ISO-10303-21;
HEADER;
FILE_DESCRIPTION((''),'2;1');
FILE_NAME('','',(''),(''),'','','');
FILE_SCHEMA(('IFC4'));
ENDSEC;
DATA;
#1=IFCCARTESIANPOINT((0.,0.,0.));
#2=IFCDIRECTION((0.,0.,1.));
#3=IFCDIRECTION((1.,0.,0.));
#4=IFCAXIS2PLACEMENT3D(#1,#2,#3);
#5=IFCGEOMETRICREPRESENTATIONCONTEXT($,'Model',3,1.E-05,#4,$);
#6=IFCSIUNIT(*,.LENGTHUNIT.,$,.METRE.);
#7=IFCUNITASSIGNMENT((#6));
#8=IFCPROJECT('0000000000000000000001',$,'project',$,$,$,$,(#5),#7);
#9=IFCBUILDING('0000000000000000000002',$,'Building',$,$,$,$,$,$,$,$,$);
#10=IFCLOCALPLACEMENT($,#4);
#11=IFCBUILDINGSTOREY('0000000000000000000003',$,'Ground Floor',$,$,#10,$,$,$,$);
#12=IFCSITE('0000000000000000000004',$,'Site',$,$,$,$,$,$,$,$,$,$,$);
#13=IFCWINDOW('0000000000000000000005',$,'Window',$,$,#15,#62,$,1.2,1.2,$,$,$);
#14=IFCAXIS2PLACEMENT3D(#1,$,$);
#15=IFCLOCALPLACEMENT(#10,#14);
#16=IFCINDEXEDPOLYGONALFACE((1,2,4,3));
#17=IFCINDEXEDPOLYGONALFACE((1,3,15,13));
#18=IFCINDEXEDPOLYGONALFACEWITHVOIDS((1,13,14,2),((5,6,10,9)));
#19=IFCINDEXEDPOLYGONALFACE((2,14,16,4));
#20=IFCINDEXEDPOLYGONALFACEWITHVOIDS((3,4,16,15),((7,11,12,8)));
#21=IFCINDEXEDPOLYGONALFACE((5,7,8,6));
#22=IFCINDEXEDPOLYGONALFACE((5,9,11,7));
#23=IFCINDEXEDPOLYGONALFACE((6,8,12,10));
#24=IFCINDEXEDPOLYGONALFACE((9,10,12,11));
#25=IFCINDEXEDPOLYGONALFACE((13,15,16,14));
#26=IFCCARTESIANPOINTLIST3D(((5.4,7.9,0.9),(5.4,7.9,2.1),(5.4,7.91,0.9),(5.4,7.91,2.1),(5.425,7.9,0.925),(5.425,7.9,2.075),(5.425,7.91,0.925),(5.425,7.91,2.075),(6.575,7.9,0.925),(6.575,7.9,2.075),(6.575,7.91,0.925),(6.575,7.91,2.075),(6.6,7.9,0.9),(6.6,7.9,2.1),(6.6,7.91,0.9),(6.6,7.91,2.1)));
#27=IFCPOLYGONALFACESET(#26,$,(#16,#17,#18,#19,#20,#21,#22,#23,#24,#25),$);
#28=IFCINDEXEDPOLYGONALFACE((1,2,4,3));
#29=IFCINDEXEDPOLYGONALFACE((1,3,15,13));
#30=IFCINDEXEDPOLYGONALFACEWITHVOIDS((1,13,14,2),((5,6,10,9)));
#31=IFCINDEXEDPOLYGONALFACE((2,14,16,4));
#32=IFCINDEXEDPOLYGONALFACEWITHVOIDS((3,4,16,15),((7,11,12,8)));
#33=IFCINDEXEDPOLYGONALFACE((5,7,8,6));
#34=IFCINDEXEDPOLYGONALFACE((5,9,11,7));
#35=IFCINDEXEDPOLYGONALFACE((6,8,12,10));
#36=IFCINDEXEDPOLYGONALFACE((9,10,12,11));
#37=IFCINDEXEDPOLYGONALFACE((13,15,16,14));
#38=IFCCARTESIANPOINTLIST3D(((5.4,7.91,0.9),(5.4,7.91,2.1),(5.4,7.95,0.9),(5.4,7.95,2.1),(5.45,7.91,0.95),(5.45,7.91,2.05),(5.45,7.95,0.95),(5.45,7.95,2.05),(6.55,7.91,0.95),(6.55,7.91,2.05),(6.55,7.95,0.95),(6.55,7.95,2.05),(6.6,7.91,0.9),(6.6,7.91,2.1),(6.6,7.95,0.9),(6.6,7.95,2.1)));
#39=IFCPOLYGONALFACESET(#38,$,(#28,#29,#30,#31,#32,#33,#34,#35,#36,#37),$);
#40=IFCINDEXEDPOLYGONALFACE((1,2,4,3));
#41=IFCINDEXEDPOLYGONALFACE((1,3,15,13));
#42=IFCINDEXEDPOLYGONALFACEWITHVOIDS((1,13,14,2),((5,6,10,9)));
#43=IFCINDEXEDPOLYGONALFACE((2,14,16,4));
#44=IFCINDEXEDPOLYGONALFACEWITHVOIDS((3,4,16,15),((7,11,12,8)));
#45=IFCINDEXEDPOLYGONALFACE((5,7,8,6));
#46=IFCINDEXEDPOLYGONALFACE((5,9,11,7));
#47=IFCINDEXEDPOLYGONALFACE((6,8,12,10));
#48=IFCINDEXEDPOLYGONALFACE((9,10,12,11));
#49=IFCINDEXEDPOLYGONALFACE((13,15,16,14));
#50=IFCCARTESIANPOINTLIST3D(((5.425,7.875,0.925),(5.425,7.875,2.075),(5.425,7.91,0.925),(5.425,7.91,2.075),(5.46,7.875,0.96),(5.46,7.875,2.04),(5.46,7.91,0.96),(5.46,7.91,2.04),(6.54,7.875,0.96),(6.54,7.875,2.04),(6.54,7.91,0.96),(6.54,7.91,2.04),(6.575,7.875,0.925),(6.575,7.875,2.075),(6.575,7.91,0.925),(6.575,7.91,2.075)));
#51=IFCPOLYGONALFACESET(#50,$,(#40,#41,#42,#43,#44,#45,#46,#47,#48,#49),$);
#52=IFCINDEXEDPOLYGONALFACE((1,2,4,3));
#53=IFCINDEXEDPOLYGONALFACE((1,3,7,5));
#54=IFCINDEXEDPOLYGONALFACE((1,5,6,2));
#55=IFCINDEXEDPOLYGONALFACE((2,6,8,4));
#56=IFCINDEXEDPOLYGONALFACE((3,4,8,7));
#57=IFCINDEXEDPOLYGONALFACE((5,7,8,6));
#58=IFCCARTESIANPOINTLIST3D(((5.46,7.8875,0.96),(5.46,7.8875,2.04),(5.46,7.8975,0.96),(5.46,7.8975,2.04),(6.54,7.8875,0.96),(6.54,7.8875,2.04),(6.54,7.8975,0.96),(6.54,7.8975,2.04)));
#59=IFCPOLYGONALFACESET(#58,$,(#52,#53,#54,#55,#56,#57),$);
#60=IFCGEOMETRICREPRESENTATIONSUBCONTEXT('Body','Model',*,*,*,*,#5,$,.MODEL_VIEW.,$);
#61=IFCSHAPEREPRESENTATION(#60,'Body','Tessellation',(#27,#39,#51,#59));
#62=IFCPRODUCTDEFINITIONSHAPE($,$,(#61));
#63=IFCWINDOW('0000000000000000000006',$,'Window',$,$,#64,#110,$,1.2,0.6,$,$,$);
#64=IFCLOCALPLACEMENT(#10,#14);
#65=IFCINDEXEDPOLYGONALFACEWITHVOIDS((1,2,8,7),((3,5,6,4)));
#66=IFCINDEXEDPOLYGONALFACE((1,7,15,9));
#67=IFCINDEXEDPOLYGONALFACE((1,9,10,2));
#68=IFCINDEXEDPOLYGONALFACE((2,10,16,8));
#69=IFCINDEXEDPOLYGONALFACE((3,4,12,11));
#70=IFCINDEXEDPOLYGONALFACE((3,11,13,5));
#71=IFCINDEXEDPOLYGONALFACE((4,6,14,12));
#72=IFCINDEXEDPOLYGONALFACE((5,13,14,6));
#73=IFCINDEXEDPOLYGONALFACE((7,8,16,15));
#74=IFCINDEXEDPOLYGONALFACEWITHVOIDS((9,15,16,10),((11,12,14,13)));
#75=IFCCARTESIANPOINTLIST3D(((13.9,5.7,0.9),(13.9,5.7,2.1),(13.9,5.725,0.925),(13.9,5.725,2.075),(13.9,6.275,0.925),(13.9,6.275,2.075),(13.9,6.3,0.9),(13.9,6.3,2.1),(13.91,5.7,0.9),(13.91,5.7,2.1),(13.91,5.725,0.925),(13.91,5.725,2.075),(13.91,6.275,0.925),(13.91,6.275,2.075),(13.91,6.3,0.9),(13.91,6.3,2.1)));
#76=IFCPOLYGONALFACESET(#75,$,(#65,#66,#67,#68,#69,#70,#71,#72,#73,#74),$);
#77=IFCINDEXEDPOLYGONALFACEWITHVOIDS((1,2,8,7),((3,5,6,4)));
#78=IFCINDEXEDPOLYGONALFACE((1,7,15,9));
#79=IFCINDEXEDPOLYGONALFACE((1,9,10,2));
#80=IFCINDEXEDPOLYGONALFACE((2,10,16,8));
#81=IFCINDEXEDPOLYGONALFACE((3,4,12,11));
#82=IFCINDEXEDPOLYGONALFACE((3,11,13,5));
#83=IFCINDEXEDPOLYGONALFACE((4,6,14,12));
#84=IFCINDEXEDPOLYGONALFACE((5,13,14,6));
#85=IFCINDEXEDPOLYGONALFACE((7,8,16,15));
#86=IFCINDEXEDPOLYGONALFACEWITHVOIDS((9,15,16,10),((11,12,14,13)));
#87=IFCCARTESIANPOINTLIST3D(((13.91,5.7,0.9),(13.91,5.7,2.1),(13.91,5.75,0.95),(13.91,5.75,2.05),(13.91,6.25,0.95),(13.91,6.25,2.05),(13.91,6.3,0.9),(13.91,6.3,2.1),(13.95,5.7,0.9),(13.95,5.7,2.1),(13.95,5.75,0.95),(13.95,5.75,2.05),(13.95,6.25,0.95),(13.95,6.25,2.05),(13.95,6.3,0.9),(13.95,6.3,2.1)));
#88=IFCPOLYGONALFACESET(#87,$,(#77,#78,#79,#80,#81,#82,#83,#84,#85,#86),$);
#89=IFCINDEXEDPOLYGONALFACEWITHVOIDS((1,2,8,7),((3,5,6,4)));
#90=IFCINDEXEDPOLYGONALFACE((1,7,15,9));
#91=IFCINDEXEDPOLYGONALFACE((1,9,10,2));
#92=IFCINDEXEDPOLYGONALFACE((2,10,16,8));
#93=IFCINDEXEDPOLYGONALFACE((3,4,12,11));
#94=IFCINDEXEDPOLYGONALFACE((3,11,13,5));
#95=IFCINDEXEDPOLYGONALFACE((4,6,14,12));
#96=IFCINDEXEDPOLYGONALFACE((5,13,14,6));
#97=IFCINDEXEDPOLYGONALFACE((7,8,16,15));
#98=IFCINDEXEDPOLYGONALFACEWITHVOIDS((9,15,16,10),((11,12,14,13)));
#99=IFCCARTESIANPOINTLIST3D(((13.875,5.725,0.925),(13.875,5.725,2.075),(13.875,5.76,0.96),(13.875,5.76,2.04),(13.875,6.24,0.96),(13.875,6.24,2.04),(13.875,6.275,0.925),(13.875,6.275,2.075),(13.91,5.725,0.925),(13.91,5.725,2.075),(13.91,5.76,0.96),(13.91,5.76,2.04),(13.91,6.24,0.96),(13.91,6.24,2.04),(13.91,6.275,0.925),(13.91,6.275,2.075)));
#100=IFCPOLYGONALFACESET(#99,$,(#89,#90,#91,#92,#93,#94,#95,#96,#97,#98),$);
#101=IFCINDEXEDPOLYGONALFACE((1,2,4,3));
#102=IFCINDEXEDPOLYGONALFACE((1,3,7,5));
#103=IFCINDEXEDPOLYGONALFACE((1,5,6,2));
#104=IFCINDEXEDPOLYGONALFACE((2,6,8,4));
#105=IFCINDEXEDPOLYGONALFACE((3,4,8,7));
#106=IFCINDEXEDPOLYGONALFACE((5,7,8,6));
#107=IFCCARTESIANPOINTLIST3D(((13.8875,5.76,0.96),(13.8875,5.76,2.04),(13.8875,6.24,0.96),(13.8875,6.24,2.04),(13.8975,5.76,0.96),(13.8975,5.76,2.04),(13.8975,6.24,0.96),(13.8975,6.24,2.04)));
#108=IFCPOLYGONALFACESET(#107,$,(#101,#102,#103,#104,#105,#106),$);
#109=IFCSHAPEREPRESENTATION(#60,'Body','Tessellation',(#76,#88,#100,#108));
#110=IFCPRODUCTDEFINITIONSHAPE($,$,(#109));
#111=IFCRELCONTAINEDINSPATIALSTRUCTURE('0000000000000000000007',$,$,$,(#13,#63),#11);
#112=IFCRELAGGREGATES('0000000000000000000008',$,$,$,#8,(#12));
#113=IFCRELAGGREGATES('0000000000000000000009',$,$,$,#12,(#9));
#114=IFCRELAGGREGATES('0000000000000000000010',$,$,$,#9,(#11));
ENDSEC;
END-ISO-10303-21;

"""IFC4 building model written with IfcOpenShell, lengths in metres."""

from ifc_helpers import new_model, si_unit, frame, origin_with_axes, place, context, subcontext, project, spatial, line, indexed_curve, outline, extrude, element, save


model = new_model("IFC4")

# Units and contexts
model_context = context("Model", 3, precision=1e-05, world=origin_with_axes())
body_context = subcontext(model_context, "Body", "Model", "MODEL_VIEW")
ifc_project = project(units=[si_unit("LENGTHUNIT", "METRE")], contexts=[model_context])

# Site, building, storey
site = spatial("IfcSite", under=ifc_project, Name="Site")
building = spatial("IfcBuilding", under=site, Name="Building")
storey_placement = place(None, origin_with_axes())
storey = spatial("IfcBuildingStorey", under=building, at=storey_placement, Name="Ground Floor")

# Windows
window_1_placement = place(storey_placement, frame((6.6, 8.0, 0.9), z_axis=(0.0, 0.0, 1.0), x_axis=(-1.0, 0.0, 0.0)))
element("IfcWindow", 1, at=window_1_placement, inside=storey, Name="Window", OverallHeight=1.2, OverallWidth=1.2, context=body_context, shape_type="SweptSolid", body=[
    extrude(outline(indexed_curve([(0.0, 0.0), (1.2, 0.0), (1.2, 1.2), (0.0, 1.2)], segments=[line(1, 2, 3, 4, 1)]), holes=[indexed_curve([(0.025, 0.025), (1.175, 0.025), (1.175, 1.175), (0.025, 1.175)], segments=[line(1, 2, 3, 4, 1)])]), frame((0.0, 0.09, 0.0), z_axis=(0.0, -1.0, 0.0), x_axis=(1.0, 0.0, 0.0)), (0.0, 0.0, -1.0), 0.01),
    extrude(outline(indexed_curve([(0.0, 0.0), (1.2, 0.0), (1.2, 1.2), (0.0, 1.2)], segments=[line(1, 2, 3, 4, 1)]), holes=[indexed_curve([(0.05, 0.05), (1.15, 0.05), (1.15, 1.15), (0.05, 1.15)], segments=[line(1, 2, 3, 4, 1)])]), frame((0.0, 0.05, 0.0), z_axis=(0.0, -1.0, 0.0), x_axis=(1.0, 0.0, 0.0)), (0.0, 0.0, -1.0), 0.04),
    extrude(outline(indexed_curve([(0.0, 0.0), (1.15, 0.0), (1.15, 1.15), (0.0, 1.15)], segments=[line(1, 2, 3, 4, 1)]), holes=[indexed_curve([(0.035, 0.035), (1.115, 0.035), (1.115, 1.115), (0.035, 1.115)], segments=[line(1, 2, 3, 4, 1)])]), frame((0.025, 0.09, 0.025), z_axis=(0.0, -1.0, 0.0), x_axis=(1.0, 0.0, 0.0)), (0.0, 0.0, -1.0), 0.035),
    extrude(outline(indexed_curve([(0.035, 0.035), (1.115, 0.035), (1.115, 1.115), (0.035, 1.115)], segments=[line(1, 2, 3, 4, 1)])), frame((0.025, 0.1025, 0.025), z_axis=(0.0, -1.0, 0.0), x_axis=(1.0, 0.0, 0.0)), (0.0, 0.0, -1.0), 0.01),
])
window_2_placement = place(storey_placement, frame((14.0, 5.7, 0.9), z_axis=(0.0, 0.0, 1.0), x_axis=(0.0, 1.0, 0.0)))
element("IfcWindow", 2, at=window_2_placement, inside=storey, Name="Window", OverallHeight=1.2, OverallWidth=0.6, context=body_context, shape_type="SweptSolid", body=[
    extrude(outline(indexed_curve([(0.0, 0.0), (0.6, 0.0), (0.6, 1.2), (0.0, 1.2)], segments=[line(1, 2, 3, 4, 1)]), holes=[indexed_curve([(0.025, 0.025), (0.575, 0.025), (0.575, 1.175), (0.025, 1.175)], segments=[line(1, 2, 3, 4, 1)])]), frame((0.0, 0.09, 0.0), z_axis=(0.0, -1.0, 0.0), x_axis=(1.0, 0.0, 0.0)), (0.0, 0.0, -1.0), 0.01),
    extrude(outline(indexed_curve([(0.0, 0.0), (0.6, 0.0), (0.6, 1.2), (0.0, 1.2)], segments=[line(1, 2, 3, 4, 1)]), holes=[indexed_curve([(0.05, 0.05), (0.55, 0.05), (0.55, 1.15), (0.05, 1.15)], segments=[line(1, 2, 3, 4, 1)])]), frame((0.0, 0.05, 0.0), z_axis=(0.0, -1.0, 0.0), x_axis=(1.0, 0.0, 0.0)), (0.0, 0.0, -1.0), 0.04),
    extrude(outline(indexed_curve([(0.0, 0.0), (0.55, 0.0), (0.55, 1.15), (0.0, 1.15)], segments=[line(1, 2, 3, 4, 1)]), holes=[indexed_curve([(0.035, 0.035), (0.515, 0.035), (0.515, 1.115), (0.035, 1.115)], segments=[line(1, 2, 3, 4, 1)])]), frame((0.025, 0.09, 0.025), z_axis=(0.0, -1.0, 0.0), x_axis=(1.0, 0.0, 0.0)), (0.0, 0.0, -1.0), 0.035),
    extrude(outline(indexed_curve([(0.035, 0.035), (0.515, 0.035), (0.515, 1.115), (0.035, 1.115)], segments=[line(1, 2, 3, 4, 1)])), frame((0.025, 0.1025, 0.025), z_axis=(0.0, -1.0, 0.0), x_axis=(1.0, 0.0, 0.0)), (0.0, 0.0, -1.0), 0.01),
])

save(model, "model.ifc")
